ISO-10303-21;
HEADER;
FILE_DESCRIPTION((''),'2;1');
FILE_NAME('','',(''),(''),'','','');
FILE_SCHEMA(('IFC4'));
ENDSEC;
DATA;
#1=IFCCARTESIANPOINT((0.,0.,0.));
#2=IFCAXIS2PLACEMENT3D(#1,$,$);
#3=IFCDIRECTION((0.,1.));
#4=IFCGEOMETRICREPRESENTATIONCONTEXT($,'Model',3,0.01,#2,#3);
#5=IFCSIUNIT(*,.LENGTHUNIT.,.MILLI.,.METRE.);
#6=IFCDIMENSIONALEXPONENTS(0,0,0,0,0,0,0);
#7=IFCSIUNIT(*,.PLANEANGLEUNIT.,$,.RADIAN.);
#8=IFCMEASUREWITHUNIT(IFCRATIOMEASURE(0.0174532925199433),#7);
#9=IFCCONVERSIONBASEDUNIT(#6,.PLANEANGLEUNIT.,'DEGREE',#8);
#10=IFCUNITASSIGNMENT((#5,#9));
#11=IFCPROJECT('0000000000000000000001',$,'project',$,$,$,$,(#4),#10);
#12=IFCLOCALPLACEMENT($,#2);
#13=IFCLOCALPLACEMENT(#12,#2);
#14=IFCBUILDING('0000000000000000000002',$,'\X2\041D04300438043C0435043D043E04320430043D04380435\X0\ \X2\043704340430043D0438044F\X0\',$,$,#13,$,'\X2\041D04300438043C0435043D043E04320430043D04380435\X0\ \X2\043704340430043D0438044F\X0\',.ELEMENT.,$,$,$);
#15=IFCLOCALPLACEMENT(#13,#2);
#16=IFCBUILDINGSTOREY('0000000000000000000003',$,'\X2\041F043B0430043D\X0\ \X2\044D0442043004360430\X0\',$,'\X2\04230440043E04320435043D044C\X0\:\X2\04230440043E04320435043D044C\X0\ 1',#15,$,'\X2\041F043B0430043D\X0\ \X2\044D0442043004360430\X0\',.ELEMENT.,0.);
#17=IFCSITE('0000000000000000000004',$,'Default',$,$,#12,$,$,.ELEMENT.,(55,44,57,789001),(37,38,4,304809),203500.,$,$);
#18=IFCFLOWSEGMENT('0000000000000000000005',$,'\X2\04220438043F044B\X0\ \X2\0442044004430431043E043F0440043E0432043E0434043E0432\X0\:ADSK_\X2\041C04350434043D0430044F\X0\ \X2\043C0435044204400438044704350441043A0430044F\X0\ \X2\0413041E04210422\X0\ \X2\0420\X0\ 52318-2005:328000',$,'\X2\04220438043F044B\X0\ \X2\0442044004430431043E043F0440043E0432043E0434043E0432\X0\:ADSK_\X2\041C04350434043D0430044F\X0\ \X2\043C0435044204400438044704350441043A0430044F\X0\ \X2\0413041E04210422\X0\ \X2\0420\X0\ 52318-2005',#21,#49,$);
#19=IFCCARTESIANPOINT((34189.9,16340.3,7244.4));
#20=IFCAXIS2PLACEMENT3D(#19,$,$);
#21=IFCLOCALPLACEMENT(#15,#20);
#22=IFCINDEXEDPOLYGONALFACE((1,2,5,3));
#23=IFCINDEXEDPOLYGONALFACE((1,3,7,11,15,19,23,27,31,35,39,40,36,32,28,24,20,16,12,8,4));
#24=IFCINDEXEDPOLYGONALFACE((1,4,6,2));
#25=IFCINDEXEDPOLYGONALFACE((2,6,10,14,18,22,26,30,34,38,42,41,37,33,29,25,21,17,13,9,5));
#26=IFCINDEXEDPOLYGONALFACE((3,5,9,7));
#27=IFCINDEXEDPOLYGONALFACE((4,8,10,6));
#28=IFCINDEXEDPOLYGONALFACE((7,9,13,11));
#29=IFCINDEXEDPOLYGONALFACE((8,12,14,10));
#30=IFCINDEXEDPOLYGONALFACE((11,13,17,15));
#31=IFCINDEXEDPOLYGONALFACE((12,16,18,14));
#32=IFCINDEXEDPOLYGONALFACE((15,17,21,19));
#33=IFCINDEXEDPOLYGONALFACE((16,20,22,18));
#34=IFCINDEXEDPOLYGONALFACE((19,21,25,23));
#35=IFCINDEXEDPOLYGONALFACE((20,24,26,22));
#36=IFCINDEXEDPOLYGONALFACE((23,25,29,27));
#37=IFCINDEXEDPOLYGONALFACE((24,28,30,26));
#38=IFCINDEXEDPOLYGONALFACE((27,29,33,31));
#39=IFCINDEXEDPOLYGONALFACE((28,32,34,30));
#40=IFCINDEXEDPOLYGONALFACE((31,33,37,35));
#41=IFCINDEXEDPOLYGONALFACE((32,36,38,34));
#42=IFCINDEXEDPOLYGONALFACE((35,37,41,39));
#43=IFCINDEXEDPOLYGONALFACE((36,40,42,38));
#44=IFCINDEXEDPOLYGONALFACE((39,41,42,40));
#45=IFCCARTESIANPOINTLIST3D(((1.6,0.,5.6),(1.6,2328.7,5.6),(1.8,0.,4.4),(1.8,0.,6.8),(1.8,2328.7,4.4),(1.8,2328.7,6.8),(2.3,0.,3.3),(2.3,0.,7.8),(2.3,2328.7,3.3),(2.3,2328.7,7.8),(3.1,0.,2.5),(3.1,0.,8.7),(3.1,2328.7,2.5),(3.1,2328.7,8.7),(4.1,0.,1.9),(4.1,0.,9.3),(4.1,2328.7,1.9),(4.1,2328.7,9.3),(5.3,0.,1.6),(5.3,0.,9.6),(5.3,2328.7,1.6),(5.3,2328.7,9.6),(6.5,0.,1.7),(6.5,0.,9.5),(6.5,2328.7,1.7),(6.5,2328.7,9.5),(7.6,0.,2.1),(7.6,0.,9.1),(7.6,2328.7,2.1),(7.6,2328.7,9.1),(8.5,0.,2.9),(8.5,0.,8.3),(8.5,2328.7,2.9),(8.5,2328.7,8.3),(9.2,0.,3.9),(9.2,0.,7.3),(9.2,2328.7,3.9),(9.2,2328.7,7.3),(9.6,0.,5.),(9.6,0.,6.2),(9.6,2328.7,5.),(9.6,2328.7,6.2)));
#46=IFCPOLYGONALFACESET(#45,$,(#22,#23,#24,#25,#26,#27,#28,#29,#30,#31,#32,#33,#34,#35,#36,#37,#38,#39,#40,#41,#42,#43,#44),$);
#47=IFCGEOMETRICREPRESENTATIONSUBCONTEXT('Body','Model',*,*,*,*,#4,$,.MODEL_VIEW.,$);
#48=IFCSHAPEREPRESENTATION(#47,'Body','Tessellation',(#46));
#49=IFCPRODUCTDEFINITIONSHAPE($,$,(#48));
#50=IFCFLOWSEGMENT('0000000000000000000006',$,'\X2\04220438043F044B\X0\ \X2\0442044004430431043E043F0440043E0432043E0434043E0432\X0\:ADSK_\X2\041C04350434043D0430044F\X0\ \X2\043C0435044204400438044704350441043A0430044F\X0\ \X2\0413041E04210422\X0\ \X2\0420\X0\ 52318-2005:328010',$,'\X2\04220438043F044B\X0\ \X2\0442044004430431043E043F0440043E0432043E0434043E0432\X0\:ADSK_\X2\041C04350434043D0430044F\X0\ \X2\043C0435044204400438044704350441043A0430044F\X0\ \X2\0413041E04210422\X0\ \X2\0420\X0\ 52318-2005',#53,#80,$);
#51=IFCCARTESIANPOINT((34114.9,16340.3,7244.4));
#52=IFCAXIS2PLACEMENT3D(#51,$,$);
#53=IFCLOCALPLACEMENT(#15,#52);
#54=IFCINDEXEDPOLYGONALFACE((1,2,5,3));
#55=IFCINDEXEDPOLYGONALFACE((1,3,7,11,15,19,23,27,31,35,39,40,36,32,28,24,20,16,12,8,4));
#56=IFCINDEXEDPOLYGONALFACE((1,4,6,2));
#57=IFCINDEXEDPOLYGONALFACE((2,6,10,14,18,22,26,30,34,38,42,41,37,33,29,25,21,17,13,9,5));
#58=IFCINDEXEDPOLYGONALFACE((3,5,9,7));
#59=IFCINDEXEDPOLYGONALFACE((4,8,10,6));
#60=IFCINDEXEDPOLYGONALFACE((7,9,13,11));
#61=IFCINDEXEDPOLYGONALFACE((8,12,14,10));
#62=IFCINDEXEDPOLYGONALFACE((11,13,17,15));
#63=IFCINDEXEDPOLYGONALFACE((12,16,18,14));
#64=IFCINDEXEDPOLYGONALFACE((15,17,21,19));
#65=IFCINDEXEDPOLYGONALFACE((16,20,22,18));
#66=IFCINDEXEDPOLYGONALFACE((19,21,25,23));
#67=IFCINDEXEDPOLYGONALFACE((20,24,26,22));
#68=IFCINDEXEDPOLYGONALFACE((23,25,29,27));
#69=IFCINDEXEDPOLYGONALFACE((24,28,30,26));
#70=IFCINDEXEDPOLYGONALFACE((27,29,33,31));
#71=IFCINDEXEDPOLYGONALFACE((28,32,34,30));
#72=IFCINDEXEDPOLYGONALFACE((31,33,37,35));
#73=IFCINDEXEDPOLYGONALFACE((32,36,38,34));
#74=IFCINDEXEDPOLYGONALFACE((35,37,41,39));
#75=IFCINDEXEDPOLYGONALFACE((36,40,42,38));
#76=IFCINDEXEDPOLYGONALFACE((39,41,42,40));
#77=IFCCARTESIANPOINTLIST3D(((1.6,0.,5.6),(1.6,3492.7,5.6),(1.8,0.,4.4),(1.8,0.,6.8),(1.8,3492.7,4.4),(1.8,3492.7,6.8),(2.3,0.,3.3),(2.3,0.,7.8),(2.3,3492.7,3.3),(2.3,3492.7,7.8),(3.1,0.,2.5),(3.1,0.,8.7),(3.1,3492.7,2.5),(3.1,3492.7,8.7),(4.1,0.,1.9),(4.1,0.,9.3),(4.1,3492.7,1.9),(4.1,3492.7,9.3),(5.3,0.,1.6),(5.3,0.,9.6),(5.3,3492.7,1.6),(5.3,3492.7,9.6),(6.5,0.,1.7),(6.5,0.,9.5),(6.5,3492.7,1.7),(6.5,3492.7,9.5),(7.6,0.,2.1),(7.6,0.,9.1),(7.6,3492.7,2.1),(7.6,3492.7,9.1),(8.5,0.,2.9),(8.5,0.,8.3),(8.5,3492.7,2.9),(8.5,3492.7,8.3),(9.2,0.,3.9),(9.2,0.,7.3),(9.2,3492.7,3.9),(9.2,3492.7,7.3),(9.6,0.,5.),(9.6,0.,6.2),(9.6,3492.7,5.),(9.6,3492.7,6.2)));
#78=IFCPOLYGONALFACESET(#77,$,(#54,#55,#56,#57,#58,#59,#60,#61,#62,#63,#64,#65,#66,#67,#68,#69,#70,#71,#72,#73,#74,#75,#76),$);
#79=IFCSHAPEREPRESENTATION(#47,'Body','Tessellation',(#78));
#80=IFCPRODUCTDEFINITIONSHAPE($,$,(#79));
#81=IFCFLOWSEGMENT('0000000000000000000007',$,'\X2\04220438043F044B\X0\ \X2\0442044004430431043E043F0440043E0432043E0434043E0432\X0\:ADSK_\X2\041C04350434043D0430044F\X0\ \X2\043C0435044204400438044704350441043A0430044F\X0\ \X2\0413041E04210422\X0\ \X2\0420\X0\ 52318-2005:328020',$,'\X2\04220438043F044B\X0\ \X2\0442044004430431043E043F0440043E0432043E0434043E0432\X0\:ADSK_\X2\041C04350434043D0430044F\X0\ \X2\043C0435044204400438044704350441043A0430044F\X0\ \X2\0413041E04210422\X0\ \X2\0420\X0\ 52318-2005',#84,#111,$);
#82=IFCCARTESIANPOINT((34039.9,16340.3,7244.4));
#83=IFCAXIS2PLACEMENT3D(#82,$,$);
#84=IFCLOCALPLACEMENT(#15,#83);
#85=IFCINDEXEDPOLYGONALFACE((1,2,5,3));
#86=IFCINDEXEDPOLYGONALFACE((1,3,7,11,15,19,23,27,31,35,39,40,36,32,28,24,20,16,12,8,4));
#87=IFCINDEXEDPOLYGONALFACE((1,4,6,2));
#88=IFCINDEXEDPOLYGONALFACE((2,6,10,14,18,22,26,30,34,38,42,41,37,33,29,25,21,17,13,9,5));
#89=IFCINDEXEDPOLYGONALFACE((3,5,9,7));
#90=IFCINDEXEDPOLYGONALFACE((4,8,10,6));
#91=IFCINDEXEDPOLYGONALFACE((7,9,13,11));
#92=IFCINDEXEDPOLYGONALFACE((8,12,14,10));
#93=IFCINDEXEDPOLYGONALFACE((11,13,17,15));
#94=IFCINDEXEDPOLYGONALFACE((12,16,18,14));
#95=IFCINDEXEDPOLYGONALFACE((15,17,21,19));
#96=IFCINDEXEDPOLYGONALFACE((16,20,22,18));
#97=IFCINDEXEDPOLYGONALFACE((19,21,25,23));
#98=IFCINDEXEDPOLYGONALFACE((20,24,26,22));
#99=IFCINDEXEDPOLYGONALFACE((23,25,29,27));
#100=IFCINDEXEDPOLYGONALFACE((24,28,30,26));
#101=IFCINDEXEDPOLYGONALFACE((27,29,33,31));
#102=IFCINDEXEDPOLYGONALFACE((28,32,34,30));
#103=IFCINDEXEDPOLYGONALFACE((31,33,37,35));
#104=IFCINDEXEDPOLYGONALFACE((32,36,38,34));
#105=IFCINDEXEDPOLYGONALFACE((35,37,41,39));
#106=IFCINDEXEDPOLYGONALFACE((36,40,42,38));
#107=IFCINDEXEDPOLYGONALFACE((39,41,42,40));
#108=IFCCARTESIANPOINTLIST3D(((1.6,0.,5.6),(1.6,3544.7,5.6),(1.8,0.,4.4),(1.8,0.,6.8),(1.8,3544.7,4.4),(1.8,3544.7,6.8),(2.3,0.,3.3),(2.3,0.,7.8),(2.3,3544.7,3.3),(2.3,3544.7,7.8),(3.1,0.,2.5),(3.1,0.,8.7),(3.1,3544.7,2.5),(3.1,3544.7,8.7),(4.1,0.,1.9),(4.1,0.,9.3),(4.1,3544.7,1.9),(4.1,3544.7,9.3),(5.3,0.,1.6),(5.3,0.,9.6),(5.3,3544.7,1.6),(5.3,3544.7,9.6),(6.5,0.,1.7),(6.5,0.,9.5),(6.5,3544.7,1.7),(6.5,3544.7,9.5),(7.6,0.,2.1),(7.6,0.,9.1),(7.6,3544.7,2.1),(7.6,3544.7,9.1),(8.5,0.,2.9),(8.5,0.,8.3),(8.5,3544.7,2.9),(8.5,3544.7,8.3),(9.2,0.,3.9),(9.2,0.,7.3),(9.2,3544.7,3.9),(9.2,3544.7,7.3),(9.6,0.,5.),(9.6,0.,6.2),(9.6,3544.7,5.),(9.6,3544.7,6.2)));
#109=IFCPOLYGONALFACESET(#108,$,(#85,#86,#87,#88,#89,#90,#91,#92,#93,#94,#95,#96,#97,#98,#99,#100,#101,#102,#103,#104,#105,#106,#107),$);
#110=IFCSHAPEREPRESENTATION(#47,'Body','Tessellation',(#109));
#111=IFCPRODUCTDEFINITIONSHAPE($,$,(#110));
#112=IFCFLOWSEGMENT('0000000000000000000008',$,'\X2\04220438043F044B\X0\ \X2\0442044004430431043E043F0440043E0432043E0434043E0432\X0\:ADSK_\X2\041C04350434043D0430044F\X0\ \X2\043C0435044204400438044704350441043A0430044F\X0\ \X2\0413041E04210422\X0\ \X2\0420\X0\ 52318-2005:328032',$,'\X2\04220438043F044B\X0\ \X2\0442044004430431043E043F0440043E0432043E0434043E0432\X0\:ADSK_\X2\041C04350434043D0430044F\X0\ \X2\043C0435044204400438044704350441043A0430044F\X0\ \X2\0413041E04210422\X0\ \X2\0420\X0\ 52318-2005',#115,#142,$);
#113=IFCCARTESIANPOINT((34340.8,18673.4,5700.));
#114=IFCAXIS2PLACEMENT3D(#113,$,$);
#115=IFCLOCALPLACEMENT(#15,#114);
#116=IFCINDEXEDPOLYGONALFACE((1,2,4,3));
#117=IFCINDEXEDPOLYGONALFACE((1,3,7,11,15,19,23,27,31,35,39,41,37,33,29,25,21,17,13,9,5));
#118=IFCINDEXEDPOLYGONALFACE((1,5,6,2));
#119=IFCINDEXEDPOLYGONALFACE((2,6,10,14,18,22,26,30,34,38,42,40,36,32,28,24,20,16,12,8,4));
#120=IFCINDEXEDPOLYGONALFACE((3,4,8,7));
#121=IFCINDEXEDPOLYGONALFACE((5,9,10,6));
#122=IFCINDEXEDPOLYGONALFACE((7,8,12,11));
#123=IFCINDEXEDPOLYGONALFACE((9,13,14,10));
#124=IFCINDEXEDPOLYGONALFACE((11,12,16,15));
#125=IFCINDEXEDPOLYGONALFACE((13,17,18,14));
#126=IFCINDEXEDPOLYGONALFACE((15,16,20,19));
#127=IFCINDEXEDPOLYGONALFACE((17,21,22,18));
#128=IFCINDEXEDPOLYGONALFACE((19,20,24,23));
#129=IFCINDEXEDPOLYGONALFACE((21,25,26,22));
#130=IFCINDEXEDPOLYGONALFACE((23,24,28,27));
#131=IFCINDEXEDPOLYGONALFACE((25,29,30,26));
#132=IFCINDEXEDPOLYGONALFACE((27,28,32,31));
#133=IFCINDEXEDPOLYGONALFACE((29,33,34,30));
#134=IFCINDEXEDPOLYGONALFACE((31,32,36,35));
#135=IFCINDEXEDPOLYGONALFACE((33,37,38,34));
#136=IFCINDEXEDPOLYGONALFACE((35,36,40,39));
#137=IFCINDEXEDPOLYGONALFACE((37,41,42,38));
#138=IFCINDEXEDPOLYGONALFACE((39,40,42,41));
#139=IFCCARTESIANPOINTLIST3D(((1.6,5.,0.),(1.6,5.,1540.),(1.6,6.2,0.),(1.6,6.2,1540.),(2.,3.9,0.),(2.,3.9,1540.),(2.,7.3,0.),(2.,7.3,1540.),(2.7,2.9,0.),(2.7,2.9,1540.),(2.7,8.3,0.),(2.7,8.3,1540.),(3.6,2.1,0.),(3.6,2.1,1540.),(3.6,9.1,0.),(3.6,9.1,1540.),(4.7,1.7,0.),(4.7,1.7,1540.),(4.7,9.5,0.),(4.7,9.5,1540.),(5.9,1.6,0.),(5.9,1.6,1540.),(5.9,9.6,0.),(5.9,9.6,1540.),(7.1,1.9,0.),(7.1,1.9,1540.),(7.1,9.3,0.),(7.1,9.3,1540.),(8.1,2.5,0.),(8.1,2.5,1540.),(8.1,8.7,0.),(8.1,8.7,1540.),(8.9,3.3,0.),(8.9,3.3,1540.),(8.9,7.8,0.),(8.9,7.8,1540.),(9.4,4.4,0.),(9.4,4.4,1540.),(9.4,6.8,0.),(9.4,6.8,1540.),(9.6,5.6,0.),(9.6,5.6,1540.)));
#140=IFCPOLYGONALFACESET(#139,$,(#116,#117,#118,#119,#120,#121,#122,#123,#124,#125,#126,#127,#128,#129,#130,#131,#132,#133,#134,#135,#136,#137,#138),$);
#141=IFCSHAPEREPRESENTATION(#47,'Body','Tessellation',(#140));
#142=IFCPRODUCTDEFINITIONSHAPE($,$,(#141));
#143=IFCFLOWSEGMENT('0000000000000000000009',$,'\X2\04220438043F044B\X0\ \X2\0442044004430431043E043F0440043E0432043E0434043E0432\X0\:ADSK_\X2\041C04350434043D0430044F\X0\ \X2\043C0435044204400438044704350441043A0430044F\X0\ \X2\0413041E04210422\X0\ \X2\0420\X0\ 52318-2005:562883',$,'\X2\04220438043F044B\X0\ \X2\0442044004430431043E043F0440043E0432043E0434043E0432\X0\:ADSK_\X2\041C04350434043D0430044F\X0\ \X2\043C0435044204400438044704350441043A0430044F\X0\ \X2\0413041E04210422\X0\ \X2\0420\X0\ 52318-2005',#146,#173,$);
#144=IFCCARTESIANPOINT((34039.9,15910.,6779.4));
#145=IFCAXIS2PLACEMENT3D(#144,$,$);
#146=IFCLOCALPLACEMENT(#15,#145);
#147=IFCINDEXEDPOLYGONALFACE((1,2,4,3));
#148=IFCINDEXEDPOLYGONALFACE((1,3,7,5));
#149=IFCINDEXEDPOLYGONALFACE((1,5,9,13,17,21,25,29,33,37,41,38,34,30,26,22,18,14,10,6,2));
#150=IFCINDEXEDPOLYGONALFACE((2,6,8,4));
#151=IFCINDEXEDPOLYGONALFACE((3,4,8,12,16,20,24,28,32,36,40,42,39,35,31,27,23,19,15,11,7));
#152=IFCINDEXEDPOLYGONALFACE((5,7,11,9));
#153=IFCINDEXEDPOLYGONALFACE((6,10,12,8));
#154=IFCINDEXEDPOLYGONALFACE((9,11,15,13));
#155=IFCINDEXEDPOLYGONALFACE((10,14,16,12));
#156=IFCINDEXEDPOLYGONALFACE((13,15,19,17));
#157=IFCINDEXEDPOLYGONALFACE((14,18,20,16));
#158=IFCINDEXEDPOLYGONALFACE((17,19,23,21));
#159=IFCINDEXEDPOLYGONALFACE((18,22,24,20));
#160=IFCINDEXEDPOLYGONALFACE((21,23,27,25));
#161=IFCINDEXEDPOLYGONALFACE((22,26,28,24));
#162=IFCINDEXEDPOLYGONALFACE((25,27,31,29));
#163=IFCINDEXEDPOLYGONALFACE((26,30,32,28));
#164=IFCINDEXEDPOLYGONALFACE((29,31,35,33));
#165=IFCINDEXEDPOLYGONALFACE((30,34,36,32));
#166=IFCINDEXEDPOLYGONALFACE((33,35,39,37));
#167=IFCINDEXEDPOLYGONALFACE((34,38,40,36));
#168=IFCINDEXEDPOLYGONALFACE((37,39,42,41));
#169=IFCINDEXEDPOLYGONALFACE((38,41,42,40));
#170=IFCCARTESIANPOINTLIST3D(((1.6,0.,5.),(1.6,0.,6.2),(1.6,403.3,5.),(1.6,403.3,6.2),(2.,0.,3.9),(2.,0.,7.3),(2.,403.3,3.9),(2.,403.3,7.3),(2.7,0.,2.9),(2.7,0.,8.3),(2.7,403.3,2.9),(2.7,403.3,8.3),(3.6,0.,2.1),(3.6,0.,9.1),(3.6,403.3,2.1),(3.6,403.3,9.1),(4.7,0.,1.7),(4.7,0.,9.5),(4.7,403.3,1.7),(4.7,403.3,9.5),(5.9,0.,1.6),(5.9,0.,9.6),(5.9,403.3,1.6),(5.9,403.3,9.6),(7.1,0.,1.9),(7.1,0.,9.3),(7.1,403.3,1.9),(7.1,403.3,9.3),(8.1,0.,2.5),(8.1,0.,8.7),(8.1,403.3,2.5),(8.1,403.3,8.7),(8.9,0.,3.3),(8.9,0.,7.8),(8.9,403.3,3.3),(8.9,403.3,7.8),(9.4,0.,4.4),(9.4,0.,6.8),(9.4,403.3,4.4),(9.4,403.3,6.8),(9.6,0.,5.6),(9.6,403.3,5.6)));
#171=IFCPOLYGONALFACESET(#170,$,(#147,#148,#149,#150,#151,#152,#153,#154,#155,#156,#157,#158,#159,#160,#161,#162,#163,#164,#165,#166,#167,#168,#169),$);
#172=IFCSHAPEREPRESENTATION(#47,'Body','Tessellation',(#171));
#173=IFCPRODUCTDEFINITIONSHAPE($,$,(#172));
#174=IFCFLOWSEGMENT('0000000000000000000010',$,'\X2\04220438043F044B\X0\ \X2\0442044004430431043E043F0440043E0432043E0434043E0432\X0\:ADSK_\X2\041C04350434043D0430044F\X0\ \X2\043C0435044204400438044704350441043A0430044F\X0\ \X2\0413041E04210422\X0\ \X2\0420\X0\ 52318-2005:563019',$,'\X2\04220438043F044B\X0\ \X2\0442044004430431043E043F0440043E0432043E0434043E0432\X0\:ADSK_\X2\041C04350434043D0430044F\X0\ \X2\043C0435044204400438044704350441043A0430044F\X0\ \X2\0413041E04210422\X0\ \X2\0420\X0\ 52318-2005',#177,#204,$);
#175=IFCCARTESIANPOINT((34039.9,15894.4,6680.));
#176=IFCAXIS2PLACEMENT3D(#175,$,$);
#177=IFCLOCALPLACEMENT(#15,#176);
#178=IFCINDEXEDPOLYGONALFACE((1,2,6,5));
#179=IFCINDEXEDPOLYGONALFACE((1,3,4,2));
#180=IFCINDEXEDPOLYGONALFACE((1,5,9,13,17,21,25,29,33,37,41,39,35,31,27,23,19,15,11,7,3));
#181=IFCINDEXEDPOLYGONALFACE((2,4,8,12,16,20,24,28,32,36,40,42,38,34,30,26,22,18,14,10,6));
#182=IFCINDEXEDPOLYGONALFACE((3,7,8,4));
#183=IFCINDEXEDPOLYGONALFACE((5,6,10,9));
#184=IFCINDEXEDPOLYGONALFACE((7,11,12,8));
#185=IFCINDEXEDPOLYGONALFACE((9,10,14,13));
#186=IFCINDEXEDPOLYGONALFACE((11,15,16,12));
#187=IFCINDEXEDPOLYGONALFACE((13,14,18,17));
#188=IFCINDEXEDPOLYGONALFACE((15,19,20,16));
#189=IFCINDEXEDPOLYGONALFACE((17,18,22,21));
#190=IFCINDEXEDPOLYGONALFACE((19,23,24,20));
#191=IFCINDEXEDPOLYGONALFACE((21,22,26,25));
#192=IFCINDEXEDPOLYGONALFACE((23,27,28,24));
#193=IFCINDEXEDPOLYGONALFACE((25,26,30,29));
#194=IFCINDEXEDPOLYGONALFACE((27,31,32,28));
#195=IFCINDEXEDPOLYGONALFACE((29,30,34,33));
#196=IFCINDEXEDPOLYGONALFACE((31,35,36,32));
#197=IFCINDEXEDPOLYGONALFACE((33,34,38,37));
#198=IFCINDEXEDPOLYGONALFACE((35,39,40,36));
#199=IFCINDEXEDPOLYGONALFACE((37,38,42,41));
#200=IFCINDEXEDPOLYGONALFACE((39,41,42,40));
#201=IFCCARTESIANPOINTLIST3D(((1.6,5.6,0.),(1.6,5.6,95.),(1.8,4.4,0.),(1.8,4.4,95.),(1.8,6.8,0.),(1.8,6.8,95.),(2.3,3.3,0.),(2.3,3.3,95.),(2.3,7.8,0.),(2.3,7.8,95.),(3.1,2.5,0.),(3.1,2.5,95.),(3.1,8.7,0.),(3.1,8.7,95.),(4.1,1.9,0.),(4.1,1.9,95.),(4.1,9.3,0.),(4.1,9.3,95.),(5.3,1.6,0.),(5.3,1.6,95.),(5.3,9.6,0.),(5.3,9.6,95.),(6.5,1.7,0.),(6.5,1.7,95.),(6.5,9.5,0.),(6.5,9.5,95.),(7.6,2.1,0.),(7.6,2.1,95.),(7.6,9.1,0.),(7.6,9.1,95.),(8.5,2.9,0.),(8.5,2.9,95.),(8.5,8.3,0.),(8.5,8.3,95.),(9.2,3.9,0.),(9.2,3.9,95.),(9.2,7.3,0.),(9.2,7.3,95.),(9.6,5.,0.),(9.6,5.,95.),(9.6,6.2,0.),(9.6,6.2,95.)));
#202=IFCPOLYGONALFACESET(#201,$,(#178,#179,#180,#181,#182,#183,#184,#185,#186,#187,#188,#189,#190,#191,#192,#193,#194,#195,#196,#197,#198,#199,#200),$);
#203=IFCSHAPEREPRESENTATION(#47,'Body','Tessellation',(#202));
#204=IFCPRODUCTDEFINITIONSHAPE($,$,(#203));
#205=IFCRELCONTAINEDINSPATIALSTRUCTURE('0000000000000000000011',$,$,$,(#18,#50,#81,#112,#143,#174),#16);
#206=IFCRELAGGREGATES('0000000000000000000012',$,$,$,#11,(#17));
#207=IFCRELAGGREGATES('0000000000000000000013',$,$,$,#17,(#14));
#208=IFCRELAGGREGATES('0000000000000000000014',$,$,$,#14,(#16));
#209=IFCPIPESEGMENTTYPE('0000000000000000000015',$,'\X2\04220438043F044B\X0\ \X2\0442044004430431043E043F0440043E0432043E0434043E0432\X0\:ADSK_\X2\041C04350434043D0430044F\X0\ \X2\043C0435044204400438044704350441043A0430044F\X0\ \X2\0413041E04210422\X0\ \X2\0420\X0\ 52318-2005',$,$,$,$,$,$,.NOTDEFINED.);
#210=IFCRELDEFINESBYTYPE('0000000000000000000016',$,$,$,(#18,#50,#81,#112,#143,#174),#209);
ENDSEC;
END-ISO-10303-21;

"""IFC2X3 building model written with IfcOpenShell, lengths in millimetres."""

from ifc_helpers import new_model, entity, si_unit, converted_unit, direction, frame, frame_2d, origin, origin_2d_with_axis, place, context, subcontext, project, spatial, circle, extrude, type_object, element, save


model = new_model("IFC2X3")

# Units and contexts
model_context = context("Model", 3, precision=0.01, world=origin(), true_north=direction((0.0, 1.0)))
body_context = subcontext(model_context, "Body", "Model", "MODEL_VIEW")
ifc_project = project(units=[si_unit("LENGTHUNIT", "METRE", prefix="MILLI"), converted_unit("PLANEANGLEUNIT", "DEGREE", entity("IfcRatioMeasure", 0.0174532925199433), si_unit("PLANEANGLEUNIT", "RADIAN"), dimensions=[0, 0, 0, 0, 0, 0, 0])], contexts=[model_context])

# Site, building, storey
site_placement = place(None, frame((0.0, 0.0, 0.0)))
site = spatial("IfcSite", under=ifc_project, at=site_placement, Name="Default", CompositionType="ELEMENT", RefLatitude=(55, 44, 57, 789001), RefLongitude=(37, 38, 4, 304809), RefElevation=203500.0)
building_placement = place(site_placement, origin())
building = spatial("IfcBuilding", under=site, at=building_placement, Name="Наименование здания", LongName="Наименование здания", CompositionType="ELEMENT")
storey_placement = place(building_placement, origin())
storey = spatial("IfcBuildingStorey", under=building, at=storey_placement, Name="План этажа", ObjectType="Уровень:Уровень 1", LongName="План этажа", CompositionType="ELEMENT", Elevation=0.0)

# Flow segments
pipe_segment_type = type_object("IfcPipeSegmentType", Name="Типы трубопроводов:ADSK_Медная метрическая ГОСТ Р 52318-2005", PredefinedType="NOTDEFINED")
flow_segment_1_placement = place(storey_placement, frame((34189.9, 16340.3, 7244.4)))
element("IfcFlowSegment", 1, at=flow_segment_1_placement, inside=storey, type_object=pipe_segment_type, Name="Типы трубопроводов:ADSK_Медная метрическая ГОСТ Р 52318-2005:328000", ObjectType="Типы трубопроводов:ADSK_Медная метрическая ГОСТ Р 52318-2005", context=body_context, shape_type="SweptSolid", body=[
    extrude(circle(Radius=4.0, at=frame_2d((0.0, 0.0), x_axis=(1.0, 0.0))), frame((5.6, 0.0, 5.6), z_axis=(0.0, 1.0, 0.0), x_axis=(-1.0, 0.0, 0.0)), (0.0, 0.0, 1.0), 2328.7),
])
flow_segment_2_placement = place(storey_placement, frame((34114.9, 16340.3, 7244.4)))
element("IfcFlowSegment", 2, at=flow_segment_2_placement, inside=storey, type_object=pipe_segment_type, Name="Типы трубопроводов:ADSK_Медная метрическая ГОСТ Р 52318-2005:328010", ObjectType="Типы трубопроводов:ADSK_Медная метрическая ГОСТ Р 52318-2005", context=body_context, shape_type="SweptSolid", body=[
    extrude(circle(Radius=4.0, at=frame_2d((0.0, 0.0), x_axis=(1.0, 0.0))), frame((5.6, 0.0, 5.6), z_axis=(0.0, 1.0, 0.0), x_axis=(-1.0, 0.0, 0.0)), (0.0, 0.0, 1.0), 3492.7),
])
flow_segment_3_placement = place(storey_placement, frame((34039.9, 16340.3, 7244.4)))
element("IfcFlowSegment", 3, at=flow_segment_3_placement, inside=storey, type_object=pipe_segment_type, Name="Типы трубопроводов:ADSK_Медная метрическая ГОСТ Р 52318-2005:328020", ObjectType="Типы трубопроводов:ADSK_Медная метрическая ГОСТ Р 52318-2005", context=body_context, shape_type="SweptSolid", body=[
    extrude(circle(Radius=4.0, at=frame_2d((0.0, 0.0), x_axis=(1.0, 0.0))), frame((5.6, 0.0, 5.6), z_axis=(0.0, 1.0, 0.0), x_axis=(-1.0, 0.0, 0.0)), (0.0, 0.0, 1.0), 3544.7),
])
flow_segment_4_placement = place(storey_placement, frame((34340.8, 18673.4, 5700.0)))
element("IfcFlowSegment", 4, at=flow_segment_4_placement, inside=storey, type_object=pipe_segment_type, Name="Типы трубопроводов:ADSK_Медная метрическая ГОСТ Р 52318-2005:328032", ObjectType="Типы трубопроводов:ADSK_Медная метрическая ГОСТ Р 52318-2005", context=body_context, shape_type="SweptSolid", body=[
    extrude(circle(Radius=4.0, at=origin_2d_with_axis()), frame((5.6, 5.6, 0.0)), (0.0, 0.0, 1.0), 1540.0),
])
flow_segment_5_placement = place(storey_placement, frame((34039.9, 15910.0, 6779.4)))
element("IfcFlowSegment", 5, at=flow_segment_5_placement, inside=storey, type_object=pipe_segment_type, Name="Типы трубопроводов:ADSK_Медная метрическая ГОСТ Р 52318-2005:562883", ObjectType="Типы трубопроводов:ADSK_Медная метрическая ГОСТ Р 52318-2005", context=body_context, shape_type="SweptSolid", body=[
    extrude(circle(Radius=4.0, at=origin_2d_with_axis()), frame((5.6, 0.0, 5.6), z_axis=(0.0, 1.0, 0.0), x_axis=(1.0, 0.0, 0.0)), (0.0, 0.0, 1.0), 403.3),
])
flow_segment_6_placement = place(storey_placement, frame((34039.9, 15894.4, 6680.0)))
element("IfcFlowSegment", 6, at=flow_segment_6_placement, inside=storey, type_object=pipe_segment_type, Name="Типы трубопроводов:ADSK_Медная метрическая ГОСТ Р 52318-2005:563019", ObjectType="Типы трубопроводов:ADSK_Медная метрическая ГОСТ Р 52318-2005", context=body_context, shape_type="SweptSolid", body=[
    extrude(circle(Radius=4.0, at=origin_2d_with_axis()), frame((5.6, 5.6, 0.0), z_axis=(0.0, 0.0, 1.0), x_axis=(-1.0, 0.0, 0.0)), (0.0, 0.0, 1.0), 95.0),
])

save(model, "model.ifc")
